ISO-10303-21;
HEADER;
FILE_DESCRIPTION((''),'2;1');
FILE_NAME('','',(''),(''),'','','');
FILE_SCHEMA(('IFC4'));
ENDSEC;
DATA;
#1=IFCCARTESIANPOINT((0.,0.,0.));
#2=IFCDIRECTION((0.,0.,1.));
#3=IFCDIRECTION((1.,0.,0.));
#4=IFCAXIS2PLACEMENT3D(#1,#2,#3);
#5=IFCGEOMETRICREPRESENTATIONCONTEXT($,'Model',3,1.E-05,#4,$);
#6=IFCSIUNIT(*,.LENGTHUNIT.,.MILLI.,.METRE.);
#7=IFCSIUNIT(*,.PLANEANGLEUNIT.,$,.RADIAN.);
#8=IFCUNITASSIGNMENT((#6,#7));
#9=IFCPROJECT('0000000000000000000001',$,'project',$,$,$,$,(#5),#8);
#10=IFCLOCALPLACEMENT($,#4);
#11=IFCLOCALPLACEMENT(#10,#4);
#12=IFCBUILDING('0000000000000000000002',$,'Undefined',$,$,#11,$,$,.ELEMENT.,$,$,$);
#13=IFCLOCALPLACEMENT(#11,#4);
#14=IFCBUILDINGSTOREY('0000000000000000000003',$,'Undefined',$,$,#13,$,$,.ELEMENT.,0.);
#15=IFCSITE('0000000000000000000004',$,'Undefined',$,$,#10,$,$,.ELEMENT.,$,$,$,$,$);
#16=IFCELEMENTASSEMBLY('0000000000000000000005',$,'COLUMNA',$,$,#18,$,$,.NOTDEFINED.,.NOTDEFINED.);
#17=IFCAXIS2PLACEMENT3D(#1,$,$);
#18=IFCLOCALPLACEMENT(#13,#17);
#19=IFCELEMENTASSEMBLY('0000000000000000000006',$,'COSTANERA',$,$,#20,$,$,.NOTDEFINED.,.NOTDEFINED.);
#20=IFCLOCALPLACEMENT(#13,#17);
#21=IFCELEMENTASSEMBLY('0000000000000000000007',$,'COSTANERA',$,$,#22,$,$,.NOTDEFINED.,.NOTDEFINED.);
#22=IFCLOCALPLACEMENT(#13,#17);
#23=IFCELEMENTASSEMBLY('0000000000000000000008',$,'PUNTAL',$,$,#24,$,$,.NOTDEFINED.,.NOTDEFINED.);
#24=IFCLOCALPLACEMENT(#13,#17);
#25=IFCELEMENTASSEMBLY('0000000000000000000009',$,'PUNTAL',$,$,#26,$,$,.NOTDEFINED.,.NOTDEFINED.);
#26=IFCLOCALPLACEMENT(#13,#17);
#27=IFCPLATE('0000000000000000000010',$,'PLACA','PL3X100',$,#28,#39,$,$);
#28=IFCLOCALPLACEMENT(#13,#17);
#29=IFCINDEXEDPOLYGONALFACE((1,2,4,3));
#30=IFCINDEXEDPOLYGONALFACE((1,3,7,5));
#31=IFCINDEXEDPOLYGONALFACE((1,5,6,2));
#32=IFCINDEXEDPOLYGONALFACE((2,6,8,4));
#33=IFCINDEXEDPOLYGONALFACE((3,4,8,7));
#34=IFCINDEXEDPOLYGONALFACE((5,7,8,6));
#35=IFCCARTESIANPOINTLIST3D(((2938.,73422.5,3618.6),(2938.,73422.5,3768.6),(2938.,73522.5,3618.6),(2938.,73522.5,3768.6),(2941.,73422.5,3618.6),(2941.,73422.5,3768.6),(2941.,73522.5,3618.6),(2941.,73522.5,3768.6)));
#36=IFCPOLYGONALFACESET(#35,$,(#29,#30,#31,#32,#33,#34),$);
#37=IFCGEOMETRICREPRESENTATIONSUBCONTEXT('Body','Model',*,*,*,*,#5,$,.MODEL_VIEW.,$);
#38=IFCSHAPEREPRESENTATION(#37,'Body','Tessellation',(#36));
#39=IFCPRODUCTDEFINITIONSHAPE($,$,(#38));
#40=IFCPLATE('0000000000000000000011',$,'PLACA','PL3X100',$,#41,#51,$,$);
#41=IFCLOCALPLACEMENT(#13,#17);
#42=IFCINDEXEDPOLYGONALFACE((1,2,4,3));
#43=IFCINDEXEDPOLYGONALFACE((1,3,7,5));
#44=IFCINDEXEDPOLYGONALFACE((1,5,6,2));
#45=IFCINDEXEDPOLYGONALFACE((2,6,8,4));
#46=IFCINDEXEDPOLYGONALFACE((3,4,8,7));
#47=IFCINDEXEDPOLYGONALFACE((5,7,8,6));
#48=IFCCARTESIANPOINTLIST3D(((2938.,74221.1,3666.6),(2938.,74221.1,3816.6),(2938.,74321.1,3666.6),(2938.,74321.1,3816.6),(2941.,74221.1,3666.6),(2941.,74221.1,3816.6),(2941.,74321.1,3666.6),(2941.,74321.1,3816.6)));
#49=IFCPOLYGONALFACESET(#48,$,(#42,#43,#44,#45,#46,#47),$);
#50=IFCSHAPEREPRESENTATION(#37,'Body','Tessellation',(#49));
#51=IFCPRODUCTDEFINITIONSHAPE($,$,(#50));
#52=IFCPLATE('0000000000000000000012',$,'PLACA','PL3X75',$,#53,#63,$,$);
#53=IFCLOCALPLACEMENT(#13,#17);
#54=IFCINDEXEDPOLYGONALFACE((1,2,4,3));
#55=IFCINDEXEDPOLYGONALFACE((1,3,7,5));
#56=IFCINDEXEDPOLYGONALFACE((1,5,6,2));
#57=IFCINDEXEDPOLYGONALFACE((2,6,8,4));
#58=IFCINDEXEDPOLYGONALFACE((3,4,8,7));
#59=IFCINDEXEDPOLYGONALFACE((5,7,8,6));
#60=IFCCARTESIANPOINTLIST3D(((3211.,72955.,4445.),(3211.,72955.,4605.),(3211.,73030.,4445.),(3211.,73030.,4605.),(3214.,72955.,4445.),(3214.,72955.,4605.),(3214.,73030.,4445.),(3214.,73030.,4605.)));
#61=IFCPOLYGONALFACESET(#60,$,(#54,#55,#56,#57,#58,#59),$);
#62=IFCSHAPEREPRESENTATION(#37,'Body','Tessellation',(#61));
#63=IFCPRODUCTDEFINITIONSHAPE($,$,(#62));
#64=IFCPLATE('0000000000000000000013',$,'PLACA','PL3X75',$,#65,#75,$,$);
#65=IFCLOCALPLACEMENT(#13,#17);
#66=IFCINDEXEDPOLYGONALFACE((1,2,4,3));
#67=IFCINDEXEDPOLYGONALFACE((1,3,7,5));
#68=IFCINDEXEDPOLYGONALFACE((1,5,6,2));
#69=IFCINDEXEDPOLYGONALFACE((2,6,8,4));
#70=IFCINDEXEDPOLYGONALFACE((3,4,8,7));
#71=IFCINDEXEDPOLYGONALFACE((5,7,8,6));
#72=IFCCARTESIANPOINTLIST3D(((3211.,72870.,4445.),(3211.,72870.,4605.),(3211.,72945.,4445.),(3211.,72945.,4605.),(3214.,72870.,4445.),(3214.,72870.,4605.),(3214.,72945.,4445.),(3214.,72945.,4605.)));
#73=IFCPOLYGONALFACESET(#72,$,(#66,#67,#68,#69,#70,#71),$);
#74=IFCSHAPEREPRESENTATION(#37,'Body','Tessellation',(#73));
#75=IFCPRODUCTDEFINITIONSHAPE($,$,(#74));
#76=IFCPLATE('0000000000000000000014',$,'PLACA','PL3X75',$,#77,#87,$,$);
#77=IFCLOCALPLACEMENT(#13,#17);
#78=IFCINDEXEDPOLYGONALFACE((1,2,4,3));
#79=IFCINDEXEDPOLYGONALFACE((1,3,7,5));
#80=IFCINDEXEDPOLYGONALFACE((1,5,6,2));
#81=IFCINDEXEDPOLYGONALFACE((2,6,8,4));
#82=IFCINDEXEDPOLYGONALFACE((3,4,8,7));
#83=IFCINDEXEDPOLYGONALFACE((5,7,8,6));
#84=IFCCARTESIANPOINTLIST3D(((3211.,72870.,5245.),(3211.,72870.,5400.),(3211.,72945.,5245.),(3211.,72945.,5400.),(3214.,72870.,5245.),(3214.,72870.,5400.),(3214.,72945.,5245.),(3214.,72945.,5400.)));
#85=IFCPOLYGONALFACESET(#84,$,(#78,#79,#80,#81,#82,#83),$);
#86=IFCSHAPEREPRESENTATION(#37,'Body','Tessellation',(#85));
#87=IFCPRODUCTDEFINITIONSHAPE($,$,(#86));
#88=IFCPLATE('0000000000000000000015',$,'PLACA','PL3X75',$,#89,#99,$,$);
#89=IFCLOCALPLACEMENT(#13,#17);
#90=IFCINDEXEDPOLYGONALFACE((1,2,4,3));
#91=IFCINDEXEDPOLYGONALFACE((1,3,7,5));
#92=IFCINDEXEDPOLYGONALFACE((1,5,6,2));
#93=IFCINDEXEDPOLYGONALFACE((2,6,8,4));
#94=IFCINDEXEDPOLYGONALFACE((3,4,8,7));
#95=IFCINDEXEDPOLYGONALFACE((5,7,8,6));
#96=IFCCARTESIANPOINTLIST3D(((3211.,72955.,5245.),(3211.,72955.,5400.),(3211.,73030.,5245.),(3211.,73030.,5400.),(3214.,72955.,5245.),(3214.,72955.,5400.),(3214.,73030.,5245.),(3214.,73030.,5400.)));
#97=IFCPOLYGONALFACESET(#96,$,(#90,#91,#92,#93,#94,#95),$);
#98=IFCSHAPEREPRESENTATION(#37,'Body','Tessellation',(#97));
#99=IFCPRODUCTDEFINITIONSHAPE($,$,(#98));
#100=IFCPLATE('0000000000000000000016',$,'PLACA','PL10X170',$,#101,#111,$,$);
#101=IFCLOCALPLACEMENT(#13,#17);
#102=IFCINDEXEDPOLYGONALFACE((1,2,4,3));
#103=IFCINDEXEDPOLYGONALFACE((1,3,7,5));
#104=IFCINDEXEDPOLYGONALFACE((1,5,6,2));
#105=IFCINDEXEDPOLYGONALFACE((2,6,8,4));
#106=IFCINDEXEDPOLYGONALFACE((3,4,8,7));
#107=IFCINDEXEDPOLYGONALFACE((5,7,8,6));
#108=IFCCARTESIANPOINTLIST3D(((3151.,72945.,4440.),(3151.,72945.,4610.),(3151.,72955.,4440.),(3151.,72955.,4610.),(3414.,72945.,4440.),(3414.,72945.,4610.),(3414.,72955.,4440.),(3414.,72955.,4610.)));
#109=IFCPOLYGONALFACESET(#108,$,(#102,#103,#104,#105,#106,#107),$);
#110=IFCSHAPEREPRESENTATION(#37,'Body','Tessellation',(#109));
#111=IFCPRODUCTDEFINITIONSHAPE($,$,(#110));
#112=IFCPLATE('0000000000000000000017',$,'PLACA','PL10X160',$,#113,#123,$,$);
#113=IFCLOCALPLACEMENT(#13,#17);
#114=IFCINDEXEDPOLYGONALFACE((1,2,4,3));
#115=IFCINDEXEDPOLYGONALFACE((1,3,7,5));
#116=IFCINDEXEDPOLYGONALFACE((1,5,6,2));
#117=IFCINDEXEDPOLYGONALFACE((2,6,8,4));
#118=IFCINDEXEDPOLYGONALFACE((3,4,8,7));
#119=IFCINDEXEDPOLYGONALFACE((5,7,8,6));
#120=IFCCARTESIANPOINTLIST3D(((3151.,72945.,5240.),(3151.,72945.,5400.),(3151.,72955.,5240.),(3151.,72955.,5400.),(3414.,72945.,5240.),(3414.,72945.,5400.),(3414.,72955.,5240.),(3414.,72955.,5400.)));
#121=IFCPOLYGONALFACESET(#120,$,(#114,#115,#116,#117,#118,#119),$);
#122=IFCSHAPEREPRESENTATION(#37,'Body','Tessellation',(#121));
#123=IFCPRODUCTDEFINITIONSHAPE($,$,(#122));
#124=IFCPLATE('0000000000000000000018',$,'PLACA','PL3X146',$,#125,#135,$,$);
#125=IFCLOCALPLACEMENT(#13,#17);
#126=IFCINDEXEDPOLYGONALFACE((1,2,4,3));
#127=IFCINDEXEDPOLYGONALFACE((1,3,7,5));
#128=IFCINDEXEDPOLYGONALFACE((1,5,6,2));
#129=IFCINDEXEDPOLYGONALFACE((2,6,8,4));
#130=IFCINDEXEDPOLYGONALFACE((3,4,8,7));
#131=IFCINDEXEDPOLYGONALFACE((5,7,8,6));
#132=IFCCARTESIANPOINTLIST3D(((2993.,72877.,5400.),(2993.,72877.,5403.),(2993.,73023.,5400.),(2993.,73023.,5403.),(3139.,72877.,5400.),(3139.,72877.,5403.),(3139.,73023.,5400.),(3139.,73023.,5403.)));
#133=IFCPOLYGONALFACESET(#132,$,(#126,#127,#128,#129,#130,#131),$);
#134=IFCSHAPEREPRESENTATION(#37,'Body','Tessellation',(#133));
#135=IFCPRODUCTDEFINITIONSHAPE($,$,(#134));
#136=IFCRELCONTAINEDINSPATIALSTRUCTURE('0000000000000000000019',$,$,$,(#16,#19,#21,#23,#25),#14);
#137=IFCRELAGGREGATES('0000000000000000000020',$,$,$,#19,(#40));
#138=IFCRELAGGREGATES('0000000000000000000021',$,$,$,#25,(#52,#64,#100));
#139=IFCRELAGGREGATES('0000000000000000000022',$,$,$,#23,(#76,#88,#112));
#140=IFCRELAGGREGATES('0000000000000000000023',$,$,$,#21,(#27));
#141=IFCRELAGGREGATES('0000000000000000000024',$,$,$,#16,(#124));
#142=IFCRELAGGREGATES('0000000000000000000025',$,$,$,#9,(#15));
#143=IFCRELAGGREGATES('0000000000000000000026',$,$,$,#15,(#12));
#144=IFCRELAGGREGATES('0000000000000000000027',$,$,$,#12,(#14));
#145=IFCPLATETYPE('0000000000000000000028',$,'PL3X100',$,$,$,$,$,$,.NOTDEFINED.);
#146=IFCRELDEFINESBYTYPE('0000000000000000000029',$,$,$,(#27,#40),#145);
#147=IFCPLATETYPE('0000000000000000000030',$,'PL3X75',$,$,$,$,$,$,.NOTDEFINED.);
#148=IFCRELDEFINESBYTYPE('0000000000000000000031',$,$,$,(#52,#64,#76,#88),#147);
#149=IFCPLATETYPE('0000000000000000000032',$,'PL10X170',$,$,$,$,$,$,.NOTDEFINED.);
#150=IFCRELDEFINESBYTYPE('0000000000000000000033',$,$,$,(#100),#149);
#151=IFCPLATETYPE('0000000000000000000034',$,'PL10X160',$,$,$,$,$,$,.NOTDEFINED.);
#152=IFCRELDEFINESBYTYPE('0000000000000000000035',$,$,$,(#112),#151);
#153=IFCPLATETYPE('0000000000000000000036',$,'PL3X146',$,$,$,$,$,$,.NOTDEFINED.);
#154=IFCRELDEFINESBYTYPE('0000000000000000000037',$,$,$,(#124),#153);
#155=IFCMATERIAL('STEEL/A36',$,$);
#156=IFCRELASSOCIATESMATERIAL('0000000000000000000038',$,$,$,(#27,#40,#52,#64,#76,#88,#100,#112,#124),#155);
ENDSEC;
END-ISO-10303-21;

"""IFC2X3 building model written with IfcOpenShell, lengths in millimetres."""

from ifc_helpers import new_model, si_unit, frame, origin_with_axes, place, context, subcontext, project, spatial, polyline, outline, extrude, material, type_object, element, aggregate, save


model = new_model("IFC2X3")

# Units and contexts
model_context = context("Model", 3, precision=1e-05, world=origin_with_axes())
body_context = subcontext(model_context, "Body", "Model", "MODEL_VIEW")
ifc_project = project(units=[si_unit("LENGTHUNIT", "METRE", prefix="MILLI"), si_unit("PLANEANGLEUNIT", "RADIAN")], contexts=[model_context])

# Site, building, storey
site_placement = place(None, origin_with_axes())
site = spatial("IfcSite", under=ifc_project, at=site_placement, Name="Undefined", CompositionType="ELEMENT")
building_placement = place(site_placement, origin_with_axes())
building = spatial("IfcBuilding", under=site, at=building_placement, Name="Undefined", CompositionType="ELEMENT")
storey_placement = place(building_placement, origin_with_axes())
storey = spatial("IfcBuildingStorey", under=building, at=storey_placement, Name="Undefined", CompositionType="ELEMENT", Elevation=0.0)

# Element assembly
assembly_1_placement = place(storey_placement, origin_with_axes())
assembly_1 = element("IfcElementAssembly", 1, at=assembly_1_placement, inside=storey, Name="COLUMNA", AssemblyPlace="NOTDEFINED", PredefinedType="NOTDEFINED")
ifc_material_1 = material(Name="STEEL/A36")

# Element assemblies
assembly_2_placement = place(storey_placement, origin_with_axes())
assembly_2 = element("IfcElementAssembly", 2, at=assembly_2_placement, inside=storey, Name="COSTANERA", AssemblyPlace="NOTDEFINED", PredefinedType="NOTDEFINED")
assembly_3_placement = place(storey_placement, origin_with_axes())
assembly_3 = element("IfcElementAssembly", 3, at=assembly_3_placement, inside=storey, Name="COSTANERA", AssemblyPlace="NOTDEFINED", PredefinedType="NOTDEFINED")
assembly_4_placement = place(storey_placement, origin_with_axes())
assembly_4 = element("IfcElementAssembly", 4, at=assembly_4_placement, inside=storey, Name="PUNTAL", AssemblyPlace="NOTDEFINED", PredefinedType="NOTDEFINED")
assembly_5_placement = place(storey_placement, origin_with_axes())
assembly_5 = element("IfcElementAssembly", 5, at=assembly_5_placement, inside=storey, Name="PUNTAL", AssemblyPlace="NOTDEFINED", PredefinedType="NOTDEFINED")

# Plates
plate_type_1 = type_object("IfcPlateType", Name="PL3X100", PredefinedType="NOTDEFINED")
plate_1_placement = place(assembly_3_placement, frame((2939.5, 73422.5, 3618.6), z_axis=(1.0, 0.0, 0.0), x_axis=(0.0, 1.0, 0.0)))
plate_1 = element("IfcPlate", 6, at=plate_1_placement, type_object=plate_type_1, material=ifc_material_1, Name="PLACA", Description="PL3X100", context=body_context, shape_type="SweptSolid", body=[
    extrude(outline(polyline([(0.0, 0.0), (100.0, 0.0), (100.0, 150.0), (0.0, 150.0), (0.0, 0.0)])), frame((0.0, 0.0, -1.5), z_axis=(0.0, 0.0, 1.0), x_axis=(1.0, 0.0, 0.0)), (0.0, 0.0, 1.0), 3.0),
])
plate_2_placement = place(assembly_2_placement, frame((2939.5, 74221.1, 3666.6), z_axis=(1.0, 0.0, 0.0), x_axis=(0.0, 1.0, 0.0)))
plate_2 = element("IfcPlate", 7, at=plate_2_placement, type_object=plate_type_1, material=ifc_material_1, Name="PLACA", Description="PL3X100", context=body_context, shape_type="SweptSolid", body=[
    extrude(outline(polyline([(0.0, 0.0), (100.0, 0.0), (100.0, 150.0), (0.0, 150.0), (0.0, 0.0)])), frame((0.0, 0.0, -1.5), z_axis=(0.0, 0.0, 1.0), x_axis=(1.0, 0.0, 0.0)), (0.0, 0.0, 1.0), 3.0),
])
aggregate(assembly_2, [plate_2])
plate_type_2 = type_object("IfcPlateType", Name="PL3X75", PredefinedType="NOTDEFINED")
plate_3_placement = place(assembly_5_placement, frame((3212.5, 73030.0, 4605.0), z_axis=(1.0, 0.0, 0.0), x_axis=(0.0, -1.0, 0.0)))
plate_3 = element("IfcPlate", 8, at=plate_3_placement, type_object=plate_type_2, material=ifc_material_1, Name="PLACA", Description="PL3X75", context=body_context, shape_type="SweptSolid", body=[
    extrude(outline(polyline([(0.0, 0.0), (75.0, 0.0), (75.0, 160.0), (0.0, 160.0), (0.0, 0.0)])), frame((0.0, 0.0, -1.5), z_axis=(0.0, 0.0, 1.0), x_axis=(1.0, 0.0, 0.0)), (0.0, 0.0, 1.0), 3.0),
])
plate_4_placement = place(assembly_5_placement, frame((3212.5, 72945.0, 4605.0), z_axis=(1.0, 0.0, 0.0), x_axis=(0.0, -1.0, 0.0)))
plate_4 = element("IfcPlate", 9, at=plate_4_placement, type_object=plate_type_2, material=ifc_material_1, Name="PLACA", Description="PL3X75", context=body_context, shape_type="SweptSolid", body=[
    extrude(outline(polyline([(0.0, 0.0), (75.0, 0.0), (75.0, 160.0), (0.0, 160.0), (0.0, 0.0)])), frame((0.0, 0.0, -1.5), z_axis=(0.0, 0.0, 1.0), x_axis=(1.0, 0.0, 0.0)), (0.0, 0.0, 1.0), 3.0),
])
plate_5_placement = place(assembly_4_placement, frame((3212.5, 72870.0, 5245.0), z_axis=(1.0, 0.0, 0.0), x_axis=(0.0, 1.0, 0.0)))
plate_5 = element("IfcPlate", 10, at=plate_5_placement, type_object=plate_type_2, material=ifc_material_1, Name="PLACA", Description="PL3X75", context=body_context, shape_type="SweptSolid", body=[
    extrude(outline(polyline([(0.0, 0.0), (75.0, 0.0), (75.0, 155.0), (0.0, 155.0), (0.0, 0.0)])), frame((0.0, 0.0, -1.5), z_axis=(0.0, 0.0, 1.0), x_axis=(1.0, 0.0, 0.0)), (0.0, 0.0, 1.0), 3.0),
])
plate_6_placement = place(assembly_4_placement, frame((3212.5, 72955.0, 5245.0), z_axis=(1.0, 0.0, 0.0), x_axis=(0.0, 1.0, 0.0)))
plate_6 = element("IfcPlate", 11, at=plate_6_placement, type_object=plate_type_2, material=ifc_material_1, Name="PLACA", Description="PL3X75", context=body_context, shape_type="SweptSolid", body=[
    extrude(outline(polyline([(0.0, 0.0), (75.0, 0.0), (75.0, 155.0), (0.0, 155.0), (0.0, 0.0)])), frame((0.0, 0.0, -1.5), z_axis=(0.0, 0.0, 1.0), x_axis=(1.0, 0.0, 0.0)), (0.0, 0.0, 1.0), 3.0),
])
plate_type_3 = type_object("IfcPlateType", Name="PL10X170", PredefinedType="NOTDEFINED")
plate_7_placement = place(assembly_5_placement, frame((3151.0, 72950.0, 4525.0), z_axis=(0.0, -1.0, 0.0), x_axis=(1.0, 0.0, 0.0)))
plate_7 = element("IfcPlate", 12, at=plate_7_placement, type_object=plate_type_3, material=ifc_material_1, Name="PLACA", Description="PL10X170", context=body_context, shape_type="SweptSolid", body=[
    extrude(outline(polyline([(0.0, -85.0), (0.0, 85.0), (263.0, 85.0), (263.0, -85.0), (0.0, -85.0)])), frame((0.0, 0.0, -5.0), z_axis=(0.0, 0.0, 1.0), x_axis=(1.0, 0.0, 0.0)), (0.0, 0.0, 1.0), 10.0),
])
aggregate(assembly_5, [plate_3, plate_4, plate_7])
plate_type_4 = type_object("IfcPlateType", Name="PL10X160", PredefinedType="NOTDEFINED")
plate_8_placement = place(assembly_4_placement, frame((3151.0, 72950.0, 5320.0), z_axis=(0.0, 1.0, 0.0), x_axis=(1.0, 0.0, 0.0)))
plate_8 = element("IfcPlate", 13, at=plate_8_placement, type_object=plate_type_4, material=ifc_material_1, Name="PLACA", Description="PL10X160", context=body_context, shape_type="SweptSolid", body=[
    extrude(outline(polyline([(0.0, -80.0), (0.0, 80.0), (263.0, 80.0), (263.0, -80.0), (0.0, -80.0)])), frame((0.0, 0.0, -5.0), z_axis=(0.0, 0.0, 1.0), x_axis=(1.0, 0.0, 0.0)), (0.0, 0.0, 1.0), 10.0),
])
aggregate(assembly_4, [plate_5, plate_6, plate_8])
plate_type_5 = type_object("IfcPlateType", Name="PL3X146", PredefinedType="NOTDEFINED")
plate_9_placement = place(assembly_1_placement, frame((3139.0, 73023.0, 5401.5), z_axis=(0.0, 0.0, -1.0), x_axis=(0.0, -1.0, 0.0)))
plate_9 = element("IfcPlate", 14, at=plate_9_placement, type_object=plate_type_5, material=ifc_material_1, Name="PLACA", Description="PL3X146", context=body_context, shape_type="SweptSolid", body=[
    extrude(outline(polyline([(0.0, 0.0), (146.0, 0.0), (146.0, 146.0), (0.0, 146.0), (0.0, 0.0)])), frame((0.0, 0.0, -1.5), z_axis=(0.0, 0.0, 1.0), x_axis=(1.0, 0.0, 0.0)), (0.0, 0.0, 1.0), 3.0),
])

aggregate(assembly_3, [plate_1])
aggregate(assembly_1, [plate_9])

save(model, "model.ifc")
